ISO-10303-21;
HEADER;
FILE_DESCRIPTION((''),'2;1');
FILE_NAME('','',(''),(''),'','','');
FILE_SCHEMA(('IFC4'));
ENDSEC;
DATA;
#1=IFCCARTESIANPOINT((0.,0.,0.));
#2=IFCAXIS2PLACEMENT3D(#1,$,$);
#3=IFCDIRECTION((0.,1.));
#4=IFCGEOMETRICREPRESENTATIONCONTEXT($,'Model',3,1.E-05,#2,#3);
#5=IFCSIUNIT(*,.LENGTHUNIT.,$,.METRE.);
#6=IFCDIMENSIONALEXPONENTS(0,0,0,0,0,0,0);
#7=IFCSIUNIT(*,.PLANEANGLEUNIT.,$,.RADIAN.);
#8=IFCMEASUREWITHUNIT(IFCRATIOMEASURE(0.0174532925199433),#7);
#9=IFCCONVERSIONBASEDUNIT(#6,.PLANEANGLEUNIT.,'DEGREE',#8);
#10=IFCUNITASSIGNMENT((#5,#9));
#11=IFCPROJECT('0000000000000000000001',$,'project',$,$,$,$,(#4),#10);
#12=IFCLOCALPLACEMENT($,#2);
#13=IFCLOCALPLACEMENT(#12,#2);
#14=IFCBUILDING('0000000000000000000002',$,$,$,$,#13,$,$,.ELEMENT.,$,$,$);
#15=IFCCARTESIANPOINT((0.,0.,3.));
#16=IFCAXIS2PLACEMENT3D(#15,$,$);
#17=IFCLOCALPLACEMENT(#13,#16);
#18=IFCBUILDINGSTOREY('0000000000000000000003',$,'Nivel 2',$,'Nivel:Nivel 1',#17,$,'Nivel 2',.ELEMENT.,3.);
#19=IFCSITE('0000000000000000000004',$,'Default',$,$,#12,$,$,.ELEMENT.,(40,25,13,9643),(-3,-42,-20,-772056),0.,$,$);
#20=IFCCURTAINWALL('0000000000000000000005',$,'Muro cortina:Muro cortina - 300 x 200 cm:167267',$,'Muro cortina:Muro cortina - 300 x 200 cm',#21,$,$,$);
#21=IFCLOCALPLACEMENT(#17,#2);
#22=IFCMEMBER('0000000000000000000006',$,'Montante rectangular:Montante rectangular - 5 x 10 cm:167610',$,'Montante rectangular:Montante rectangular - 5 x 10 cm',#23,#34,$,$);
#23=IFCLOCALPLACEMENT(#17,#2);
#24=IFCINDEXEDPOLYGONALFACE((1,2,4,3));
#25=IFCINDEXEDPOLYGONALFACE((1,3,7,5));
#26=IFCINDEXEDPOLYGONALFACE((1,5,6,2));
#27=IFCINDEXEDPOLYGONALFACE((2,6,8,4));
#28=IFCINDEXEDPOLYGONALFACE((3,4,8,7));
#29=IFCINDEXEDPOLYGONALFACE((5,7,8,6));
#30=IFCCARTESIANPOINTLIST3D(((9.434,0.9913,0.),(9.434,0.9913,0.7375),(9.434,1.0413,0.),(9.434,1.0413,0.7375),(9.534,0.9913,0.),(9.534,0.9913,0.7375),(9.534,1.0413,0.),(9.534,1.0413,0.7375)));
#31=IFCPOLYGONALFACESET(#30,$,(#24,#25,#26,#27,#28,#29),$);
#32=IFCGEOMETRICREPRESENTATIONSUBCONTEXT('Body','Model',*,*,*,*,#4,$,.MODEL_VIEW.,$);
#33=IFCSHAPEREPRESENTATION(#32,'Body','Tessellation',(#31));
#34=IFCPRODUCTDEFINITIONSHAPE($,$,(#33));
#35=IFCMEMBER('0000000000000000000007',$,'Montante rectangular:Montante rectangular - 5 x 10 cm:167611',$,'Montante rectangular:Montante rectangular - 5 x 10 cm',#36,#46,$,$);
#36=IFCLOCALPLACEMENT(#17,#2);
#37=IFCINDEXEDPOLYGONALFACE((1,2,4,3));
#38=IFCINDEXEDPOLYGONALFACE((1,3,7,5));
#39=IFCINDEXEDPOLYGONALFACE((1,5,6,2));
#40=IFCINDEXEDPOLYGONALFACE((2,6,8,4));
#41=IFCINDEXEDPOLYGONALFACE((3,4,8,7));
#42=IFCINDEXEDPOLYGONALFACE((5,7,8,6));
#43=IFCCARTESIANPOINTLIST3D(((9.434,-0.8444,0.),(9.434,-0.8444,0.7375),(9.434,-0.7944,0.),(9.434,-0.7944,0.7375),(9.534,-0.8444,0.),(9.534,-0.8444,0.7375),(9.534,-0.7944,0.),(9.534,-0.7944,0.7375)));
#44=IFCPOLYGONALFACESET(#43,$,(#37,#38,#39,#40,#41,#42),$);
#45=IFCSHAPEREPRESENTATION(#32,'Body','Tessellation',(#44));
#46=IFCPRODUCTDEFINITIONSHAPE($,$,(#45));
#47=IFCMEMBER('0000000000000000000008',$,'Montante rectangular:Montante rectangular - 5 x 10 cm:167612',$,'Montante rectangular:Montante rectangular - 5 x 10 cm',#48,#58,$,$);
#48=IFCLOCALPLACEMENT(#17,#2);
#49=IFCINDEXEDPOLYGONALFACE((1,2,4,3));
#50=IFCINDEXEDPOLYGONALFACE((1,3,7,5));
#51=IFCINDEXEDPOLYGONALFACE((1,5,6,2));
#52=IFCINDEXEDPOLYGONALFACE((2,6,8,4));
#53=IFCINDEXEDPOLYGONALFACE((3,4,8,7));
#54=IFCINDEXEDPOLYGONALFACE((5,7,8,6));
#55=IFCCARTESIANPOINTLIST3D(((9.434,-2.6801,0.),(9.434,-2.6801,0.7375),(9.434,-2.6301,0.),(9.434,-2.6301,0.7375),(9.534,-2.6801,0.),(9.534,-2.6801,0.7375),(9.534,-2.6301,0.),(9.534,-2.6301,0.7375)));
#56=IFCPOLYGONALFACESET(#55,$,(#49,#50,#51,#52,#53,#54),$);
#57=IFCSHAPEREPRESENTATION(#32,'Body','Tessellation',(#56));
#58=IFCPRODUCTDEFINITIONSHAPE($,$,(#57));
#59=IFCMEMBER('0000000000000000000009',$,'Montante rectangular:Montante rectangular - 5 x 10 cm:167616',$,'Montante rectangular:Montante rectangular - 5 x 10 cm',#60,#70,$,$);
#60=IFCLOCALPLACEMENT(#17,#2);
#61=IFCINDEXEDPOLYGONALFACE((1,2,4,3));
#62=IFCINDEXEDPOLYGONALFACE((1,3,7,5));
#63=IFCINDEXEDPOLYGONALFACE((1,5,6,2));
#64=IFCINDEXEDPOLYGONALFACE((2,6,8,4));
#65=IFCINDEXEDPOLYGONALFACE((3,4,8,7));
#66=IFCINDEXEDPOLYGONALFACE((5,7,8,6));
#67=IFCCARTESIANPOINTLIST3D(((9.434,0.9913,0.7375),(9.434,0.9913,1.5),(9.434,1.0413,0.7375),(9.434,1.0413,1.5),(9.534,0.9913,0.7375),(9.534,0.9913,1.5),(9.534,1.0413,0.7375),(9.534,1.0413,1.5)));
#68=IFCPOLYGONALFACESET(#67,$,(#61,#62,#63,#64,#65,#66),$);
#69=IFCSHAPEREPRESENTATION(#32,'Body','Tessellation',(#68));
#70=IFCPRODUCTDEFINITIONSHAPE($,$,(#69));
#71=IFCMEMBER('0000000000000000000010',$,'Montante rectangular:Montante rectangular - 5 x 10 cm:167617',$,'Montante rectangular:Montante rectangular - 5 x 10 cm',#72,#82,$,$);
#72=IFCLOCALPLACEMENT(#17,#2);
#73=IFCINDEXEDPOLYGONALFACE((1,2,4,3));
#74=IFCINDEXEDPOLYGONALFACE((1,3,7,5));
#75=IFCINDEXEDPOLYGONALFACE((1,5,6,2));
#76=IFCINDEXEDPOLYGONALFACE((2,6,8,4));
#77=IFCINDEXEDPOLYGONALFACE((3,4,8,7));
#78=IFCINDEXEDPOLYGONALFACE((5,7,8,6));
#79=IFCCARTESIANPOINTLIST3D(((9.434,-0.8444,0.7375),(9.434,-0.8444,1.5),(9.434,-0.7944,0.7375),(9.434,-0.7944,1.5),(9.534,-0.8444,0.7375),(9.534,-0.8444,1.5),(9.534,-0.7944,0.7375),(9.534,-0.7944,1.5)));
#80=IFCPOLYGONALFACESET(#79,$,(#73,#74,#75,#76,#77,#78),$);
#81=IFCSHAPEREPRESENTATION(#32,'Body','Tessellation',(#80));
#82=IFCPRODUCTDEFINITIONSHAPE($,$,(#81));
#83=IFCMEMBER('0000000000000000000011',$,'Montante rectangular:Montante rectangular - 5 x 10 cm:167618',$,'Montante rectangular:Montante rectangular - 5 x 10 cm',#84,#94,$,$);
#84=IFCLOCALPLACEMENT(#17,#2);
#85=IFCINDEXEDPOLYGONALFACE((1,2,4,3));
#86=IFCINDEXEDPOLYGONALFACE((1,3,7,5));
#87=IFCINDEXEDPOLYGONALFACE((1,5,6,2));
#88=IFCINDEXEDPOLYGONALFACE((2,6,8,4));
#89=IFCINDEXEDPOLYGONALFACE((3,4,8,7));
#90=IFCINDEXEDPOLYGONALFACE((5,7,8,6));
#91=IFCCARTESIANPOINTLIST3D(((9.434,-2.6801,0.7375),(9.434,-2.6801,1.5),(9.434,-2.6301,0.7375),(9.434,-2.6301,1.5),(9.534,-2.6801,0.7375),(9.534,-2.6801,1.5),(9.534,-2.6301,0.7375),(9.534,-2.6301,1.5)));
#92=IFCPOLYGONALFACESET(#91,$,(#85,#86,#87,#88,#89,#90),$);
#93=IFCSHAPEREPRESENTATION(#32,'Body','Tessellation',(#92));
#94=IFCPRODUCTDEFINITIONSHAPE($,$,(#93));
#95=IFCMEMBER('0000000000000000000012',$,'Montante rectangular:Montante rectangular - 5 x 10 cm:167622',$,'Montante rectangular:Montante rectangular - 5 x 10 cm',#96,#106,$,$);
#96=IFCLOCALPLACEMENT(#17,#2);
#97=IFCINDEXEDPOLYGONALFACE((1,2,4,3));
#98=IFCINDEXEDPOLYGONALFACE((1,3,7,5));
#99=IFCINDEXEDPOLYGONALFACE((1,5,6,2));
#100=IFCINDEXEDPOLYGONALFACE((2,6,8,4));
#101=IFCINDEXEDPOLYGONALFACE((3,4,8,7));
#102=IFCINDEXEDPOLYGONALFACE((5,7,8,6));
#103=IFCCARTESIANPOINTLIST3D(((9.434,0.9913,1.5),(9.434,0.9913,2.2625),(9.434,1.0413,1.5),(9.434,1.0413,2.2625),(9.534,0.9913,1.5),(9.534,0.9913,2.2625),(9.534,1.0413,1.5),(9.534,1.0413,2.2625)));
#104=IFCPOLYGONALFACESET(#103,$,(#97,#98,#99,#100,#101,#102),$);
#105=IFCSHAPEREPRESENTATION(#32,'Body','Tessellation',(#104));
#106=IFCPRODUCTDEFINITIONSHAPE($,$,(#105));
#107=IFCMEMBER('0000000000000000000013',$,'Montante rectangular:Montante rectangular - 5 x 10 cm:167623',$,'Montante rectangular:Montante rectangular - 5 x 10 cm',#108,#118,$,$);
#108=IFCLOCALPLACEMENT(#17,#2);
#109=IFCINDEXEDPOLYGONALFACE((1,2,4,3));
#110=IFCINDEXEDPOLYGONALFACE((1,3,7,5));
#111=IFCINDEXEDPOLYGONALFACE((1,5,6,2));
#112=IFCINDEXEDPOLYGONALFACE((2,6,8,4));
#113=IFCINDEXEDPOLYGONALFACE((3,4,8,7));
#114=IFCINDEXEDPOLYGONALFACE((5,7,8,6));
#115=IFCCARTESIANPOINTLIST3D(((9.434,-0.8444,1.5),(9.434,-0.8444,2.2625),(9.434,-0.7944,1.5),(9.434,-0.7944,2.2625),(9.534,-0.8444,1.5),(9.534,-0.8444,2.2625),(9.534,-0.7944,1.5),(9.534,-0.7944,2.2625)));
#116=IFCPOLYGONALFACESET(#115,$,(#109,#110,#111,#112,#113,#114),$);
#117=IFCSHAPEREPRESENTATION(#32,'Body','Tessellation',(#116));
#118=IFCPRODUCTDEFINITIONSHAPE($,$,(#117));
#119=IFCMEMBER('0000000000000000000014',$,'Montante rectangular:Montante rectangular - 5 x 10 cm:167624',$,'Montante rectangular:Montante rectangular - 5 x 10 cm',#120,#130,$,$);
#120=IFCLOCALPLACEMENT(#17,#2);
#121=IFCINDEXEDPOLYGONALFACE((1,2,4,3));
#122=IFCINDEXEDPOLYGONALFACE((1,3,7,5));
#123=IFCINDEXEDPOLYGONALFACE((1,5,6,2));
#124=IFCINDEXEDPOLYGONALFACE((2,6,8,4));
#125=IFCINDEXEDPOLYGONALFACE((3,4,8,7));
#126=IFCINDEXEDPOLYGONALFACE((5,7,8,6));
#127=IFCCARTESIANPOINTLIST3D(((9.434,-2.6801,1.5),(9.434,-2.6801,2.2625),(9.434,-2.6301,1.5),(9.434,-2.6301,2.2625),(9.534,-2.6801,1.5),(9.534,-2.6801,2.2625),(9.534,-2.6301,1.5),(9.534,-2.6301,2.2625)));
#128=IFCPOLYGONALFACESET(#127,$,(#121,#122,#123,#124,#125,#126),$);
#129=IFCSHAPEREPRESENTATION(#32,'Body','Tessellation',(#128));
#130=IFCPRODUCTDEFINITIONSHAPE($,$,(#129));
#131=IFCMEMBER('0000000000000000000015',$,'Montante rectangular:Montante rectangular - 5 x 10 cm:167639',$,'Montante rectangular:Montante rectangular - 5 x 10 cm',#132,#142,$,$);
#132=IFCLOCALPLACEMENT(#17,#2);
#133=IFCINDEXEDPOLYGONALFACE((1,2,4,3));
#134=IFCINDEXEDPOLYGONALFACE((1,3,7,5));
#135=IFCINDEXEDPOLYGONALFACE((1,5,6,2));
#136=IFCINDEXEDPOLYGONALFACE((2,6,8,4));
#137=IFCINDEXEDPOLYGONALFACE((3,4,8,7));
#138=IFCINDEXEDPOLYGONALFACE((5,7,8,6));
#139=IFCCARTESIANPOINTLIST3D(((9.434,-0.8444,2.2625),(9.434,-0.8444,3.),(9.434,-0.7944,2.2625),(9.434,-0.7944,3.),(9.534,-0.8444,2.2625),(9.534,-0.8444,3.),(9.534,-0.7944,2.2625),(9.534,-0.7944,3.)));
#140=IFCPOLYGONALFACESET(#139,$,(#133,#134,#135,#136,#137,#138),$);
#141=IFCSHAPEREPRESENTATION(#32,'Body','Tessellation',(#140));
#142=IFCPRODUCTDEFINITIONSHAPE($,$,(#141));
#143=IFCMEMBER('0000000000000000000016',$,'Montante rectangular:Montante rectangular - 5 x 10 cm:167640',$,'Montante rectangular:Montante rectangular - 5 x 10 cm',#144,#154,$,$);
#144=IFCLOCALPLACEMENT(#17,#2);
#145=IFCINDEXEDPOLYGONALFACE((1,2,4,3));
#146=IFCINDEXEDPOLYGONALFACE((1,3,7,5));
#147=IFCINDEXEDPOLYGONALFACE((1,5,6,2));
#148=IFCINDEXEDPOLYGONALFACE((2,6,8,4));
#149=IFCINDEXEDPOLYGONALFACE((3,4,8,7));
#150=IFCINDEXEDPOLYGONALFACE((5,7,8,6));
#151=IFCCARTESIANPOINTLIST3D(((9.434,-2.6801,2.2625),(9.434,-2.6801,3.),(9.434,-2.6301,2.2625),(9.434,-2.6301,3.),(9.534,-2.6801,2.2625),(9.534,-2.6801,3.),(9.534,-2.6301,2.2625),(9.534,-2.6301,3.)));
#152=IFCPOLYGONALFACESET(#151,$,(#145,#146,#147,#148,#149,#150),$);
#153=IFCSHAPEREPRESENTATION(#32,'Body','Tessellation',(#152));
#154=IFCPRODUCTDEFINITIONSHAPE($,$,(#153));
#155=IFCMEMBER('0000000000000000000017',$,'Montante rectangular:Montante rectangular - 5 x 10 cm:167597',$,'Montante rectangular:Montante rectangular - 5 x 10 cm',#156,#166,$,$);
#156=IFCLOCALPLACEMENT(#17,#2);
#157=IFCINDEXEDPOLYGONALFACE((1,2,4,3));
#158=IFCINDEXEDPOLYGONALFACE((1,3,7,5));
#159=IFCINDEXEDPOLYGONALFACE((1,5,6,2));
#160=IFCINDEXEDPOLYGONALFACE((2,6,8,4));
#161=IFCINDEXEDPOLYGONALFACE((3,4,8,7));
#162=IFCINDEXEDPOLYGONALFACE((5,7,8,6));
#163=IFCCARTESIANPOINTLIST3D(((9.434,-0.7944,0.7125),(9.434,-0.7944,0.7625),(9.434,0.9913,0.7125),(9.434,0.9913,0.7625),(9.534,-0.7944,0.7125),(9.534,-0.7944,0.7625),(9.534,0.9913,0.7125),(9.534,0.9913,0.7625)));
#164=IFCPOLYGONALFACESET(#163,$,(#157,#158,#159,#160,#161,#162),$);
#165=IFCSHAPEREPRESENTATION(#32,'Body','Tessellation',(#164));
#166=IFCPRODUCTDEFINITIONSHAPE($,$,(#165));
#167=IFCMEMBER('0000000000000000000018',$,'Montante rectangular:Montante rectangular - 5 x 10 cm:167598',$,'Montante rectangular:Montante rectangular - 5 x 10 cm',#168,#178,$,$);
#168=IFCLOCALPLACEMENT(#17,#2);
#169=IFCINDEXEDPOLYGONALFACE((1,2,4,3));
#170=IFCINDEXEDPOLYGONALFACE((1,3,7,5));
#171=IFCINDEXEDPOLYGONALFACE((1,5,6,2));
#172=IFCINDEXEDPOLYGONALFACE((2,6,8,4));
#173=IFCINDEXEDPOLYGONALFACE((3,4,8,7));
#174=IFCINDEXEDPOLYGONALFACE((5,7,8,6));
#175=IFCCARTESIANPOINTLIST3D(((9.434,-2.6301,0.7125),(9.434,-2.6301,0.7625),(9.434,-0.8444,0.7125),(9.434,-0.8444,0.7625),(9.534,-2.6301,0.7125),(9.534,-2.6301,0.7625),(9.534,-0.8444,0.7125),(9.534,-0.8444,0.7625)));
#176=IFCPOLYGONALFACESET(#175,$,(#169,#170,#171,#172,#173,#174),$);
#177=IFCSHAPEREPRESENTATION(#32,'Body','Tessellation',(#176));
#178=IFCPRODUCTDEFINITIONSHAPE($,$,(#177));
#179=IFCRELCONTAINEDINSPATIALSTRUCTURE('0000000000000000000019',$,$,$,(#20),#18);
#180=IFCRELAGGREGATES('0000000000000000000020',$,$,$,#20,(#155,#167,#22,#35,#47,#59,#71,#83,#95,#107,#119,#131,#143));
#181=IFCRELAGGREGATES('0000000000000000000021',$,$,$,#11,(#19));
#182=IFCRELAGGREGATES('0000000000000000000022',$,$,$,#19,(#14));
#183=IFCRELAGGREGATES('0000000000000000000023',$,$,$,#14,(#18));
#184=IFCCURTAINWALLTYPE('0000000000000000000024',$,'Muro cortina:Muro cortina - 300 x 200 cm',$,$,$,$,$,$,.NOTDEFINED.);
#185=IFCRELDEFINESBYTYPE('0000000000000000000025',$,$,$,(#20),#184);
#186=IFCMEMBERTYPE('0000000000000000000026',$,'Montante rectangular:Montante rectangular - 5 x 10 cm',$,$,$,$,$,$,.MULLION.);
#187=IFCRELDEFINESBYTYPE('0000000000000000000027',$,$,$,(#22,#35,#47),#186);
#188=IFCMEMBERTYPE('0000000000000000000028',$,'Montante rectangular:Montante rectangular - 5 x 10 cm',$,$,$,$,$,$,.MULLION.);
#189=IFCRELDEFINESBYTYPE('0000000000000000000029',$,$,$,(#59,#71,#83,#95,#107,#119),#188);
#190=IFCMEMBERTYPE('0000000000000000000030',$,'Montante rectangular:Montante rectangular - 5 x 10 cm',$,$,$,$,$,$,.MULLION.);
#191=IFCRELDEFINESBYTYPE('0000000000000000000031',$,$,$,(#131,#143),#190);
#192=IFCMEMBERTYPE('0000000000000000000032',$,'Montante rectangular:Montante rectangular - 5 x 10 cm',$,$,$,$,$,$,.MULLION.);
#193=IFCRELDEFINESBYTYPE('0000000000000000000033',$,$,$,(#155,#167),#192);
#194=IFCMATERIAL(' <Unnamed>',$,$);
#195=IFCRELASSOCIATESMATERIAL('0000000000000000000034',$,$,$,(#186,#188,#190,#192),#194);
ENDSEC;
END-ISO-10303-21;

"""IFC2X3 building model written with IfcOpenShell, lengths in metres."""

from ifc_helpers import new_model, entity, si_unit, converted_unit, direction, frame, origin, origin_2d_with_axis, place, context, subcontext, project, spatial, rectangle, extrude, source, transform, mapped, material, type_object, type_shapes, element, aggregate, save


model = new_model("IFC2X3")

# Units and contexts
model_context = context("Model", 3, precision=1e-05, world=origin(), true_north=direction((0.0, 1.0)))
body_context = subcontext(model_context, "Body", "Model", "MODEL_VIEW")
ifc_project = project(units=[si_unit("LENGTHUNIT", "METRE"), converted_unit("PLANEANGLEUNIT", "DEGREE", entity("IfcRatioMeasure", 0.0174532925199433), si_unit("PLANEANGLEUNIT", "RADIAN"), dimensions=[0, 0, 0, 0, 0, 0, 0])], contexts=[model_context])

# Site, building, storey
site_placement = place(None, origin())
site = spatial("IfcSite", under=ifc_project, at=site_placement, Name="Default", CompositionType="ELEMENT", RefLatitude=(40, 25, 13, 9643), RefLongitude=(-3, -42, -20, -772056), RefElevation=0.0)
building_placement = place(site_placement, origin())
building = spatial("IfcBuilding", under=site, at=building_placement, CompositionType="ELEMENT")
storey_placement = place(building_placement, frame((0.0, 0.0, 3.0)))
storey = spatial("IfcBuildingStorey", under=building, at=storey_placement, Name="Nivel 2", ObjectType="Nivel:Nivel 1", LongName="Nivel 2", CompositionType="ELEMENT", Elevation=3.0)

# Curtain wall, members
curtain_wall_type = type_object("IfcCurtainWallType", Name="Muro cortina:Muro cortina - 300 x 200 cm", PredefinedType="NOTDEFINED")
curtain_wall_placement = place(storey_placement, frame((0.0, 0.0, -3.0)))
curtain_wall = element("IfcCurtainWall", 1, at=curtain_wall_placement, inside=storey, type_object=curtain_wall_type, Name="Muro cortina:Muro cortina - 300 x 200 cm:167267", ObjectType="Muro cortina:Muro cortina - 300 x 200 cm")
ifc_material_1 = material(Name=" <Unnamed>")
member_type_1 = type_object("IfcMemberType", Name="Montante rectangular:Montante rectangular - 5 x 10 cm", PredefinedType="MULLION", material=ifc_material_1)
shared_shape_1 = source(origin(), body_context, "Body", "SweptSolid", [
    extrude(rectangle(XDim=0.1, YDim=0.05, at=origin_2d_with_axis()), frame((0.0, 0.0, -0.7375), z_axis=(0.0, 0.0, 1.0), x_axis=(0.0, -1.0, 0.0)), (0.0, 0.0, 1.0), 0.7375),
])
type_shapes(member_type_1, [shared_shape_1])
member_1_placement = place(storey_placement, frame((9.484, 1.0163, 0.0), z_axis=(0.0, 0.0, -1.0), x_axis=(0.0, -1.0, 0.0)))
member_1 = element("IfcMember", 2, at=member_1_placement, type_object=member_type_1, Name="Montante rectangular:Montante rectangular - 5 x 10 cm:167610", ObjectType="Montante rectangular:Montante rectangular - 5 x 10 cm", context=body_context, shape_type="MappedRepresentation", body=[
    mapped(shared_shape_1, transform((0.0, 0.0, 0.0), scale=1.0)),
])
member_2_placement = place(storey_placement, frame((9.484, -0.8194, 0.0), z_axis=(0.0, 0.0, -1.0), x_axis=(0.0, -1.0, 0.0)))
member_2 = element("IfcMember", 3, at=member_2_placement, type_object=member_type_1, Name="Montante rectangular:Montante rectangular - 5 x 10 cm:167611", ObjectType="Montante rectangular:Montante rectangular - 5 x 10 cm", context=body_context, shape_type="MappedRepresentation", body=[
    mapped(shared_shape_1, transform((0.0, 0.0, 0.0), scale=1.0)),
])
member_3_placement = place(storey_placement, frame((9.484, -2.6551, 0.0), z_axis=(0.0, 0.0, -1.0), x_axis=(0.0, -1.0, 0.0)))
member_3 = element("IfcMember", 4, at=member_3_placement, type_object=member_type_1, Name="Montante rectangular:Montante rectangular - 5 x 10 cm:167612", ObjectType="Montante rectangular:Montante rectangular - 5 x 10 cm", context=body_context, shape_type="MappedRepresentation", body=[
    mapped(shared_shape_1, transform((0.0, 0.0, 0.0), scale=1.0)),
])
member_type_2 = type_object("IfcMemberType", Name="Montante rectangular:Montante rectangular - 5 x 10 cm", PredefinedType="MULLION", material=ifc_material_1)
shared_shape_2 = source(origin(), body_context, "Body", "SweptSolid", [
    extrude(rectangle(XDim=0.1, YDim=0.05, at=origin_2d_with_axis()), frame((0.0, 0.0, -0.7625), z_axis=(0.0, 0.0, 1.0), x_axis=(0.0, -1.0, 0.0)), (0.0, 0.0, 1.0), 0.7625),
])
type_shapes(member_type_2, [shared_shape_2])
member_4_placement = place(storey_placement, frame((9.484, 1.0163, 0.7375), z_axis=(0.0, 0.0, -1.0), x_axis=(0.0, -1.0, 0.0)))
member_4 = element("IfcMember", 5, at=member_4_placement, type_object=member_type_2, Name="Montante rectangular:Montante rectangular - 5 x 10 cm:167616", ObjectType="Montante rectangular:Montante rectangular - 5 x 10 cm", context=body_context, shape_type="MappedRepresentation", body=[
    mapped(shared_shape_2, transform((0.0, 0.0, 0.0), scale=1.0)),
])
member_5_placement = place(storey_placement, frame((9.484, -0.8194, 0.7375), z_axis=(0.0, 0.0, -1.0), x_axis=(0.0, -1.0, 0.0)))
member_5 = element("IfcMember", 6, at=member_5_placement, type_object=member_type_2, Name="Montante rectangular:Montante rectangular - 5 x 10 cm:167617", ObjectType="Montante rectangular:Montante rectangular - 5 x 10 cm", context=body_context, shape_type="MappedRepresentation", body=[
    mapped(shared_shape_2, transform((0.0, 0.0, 0.0), scale=1.0)),
])
member_6_placement = place(storey_placement, frame((9.484, -2.6551, 0.7375), z_axis=(0.0, 0.0, -1.0), x_axis=(0.0, -1.0, 0.0)))
member_6 = element("IfcMember", 7, at=member_6_placement, type_object=member_type_2, Name="Montante rectangular:Montante rectangular - 5 x 10 cm:167618", ObjectType="Montante rectangular:Montante rectangular - 5 x 10 cm", context=body_context, shape_type="MappedRepresentation", body=[
    mapped(shared_shape_2, transform((0.0, 0.0, 0.0), scale=1.0)),
])
member_7_placement = place(storey_placement, frame((9.484, 1.0163, 1.5), z_axis=(0.0, 0.0, -1.0), x_axis=(0.0, -1.0, 0.0)))
member_7 = element("IfcMember", 8, at=member_7_placement, type_object=member_type_2, Name="Montante rectangular:Montante rectangular - 5 x 10 cm:167622", ObjectType="Montante rectangular:Montante rectangular - 5 x 10 cm", context=body_context, shape_type="MappedRepresentation", body=[
    mapped(shared_shape_2, transform((0.0, 0.0, 0.0), scale=1.0)),
])
member_8_placement = place(storey_placement, frame((9.484, -0.8194, 1.5), z_axis=(0.0, 0.0, -1.0), x_axis=(0.0, -1.0, 0.0)))
member_8 = element("IfcMember", 9, at=member_8_placement, type_object=member_type_2, Name="Montante rectangular:Montante rectangular - 5 x 10 cm:167623", ObjectType="Montante rectangular:Montante rectangular - 5 x 10 cm", context=body_context, shape_type="MappedRepresentation", body=[
    mapped(shared_shape_2, transform((0.0, 0.0, 0.0), scale=1.0)),
])
member_9_placement = place(storey_placement, frame((9.484, -2.6551, 1.5), z_axis=(0.0, 0.0, -1.0), x_axis=(0.0, -1.0, 0.0)))
member_9 = element("IfcMember", 10, at=member_9_placement, type_object=member_type_2, Name="Montante rectangular:Montante rectangular - 5 x 10 cm:167624", ObjectType="Montante rectangular:Montante rectangular - 5 x 10 cm", context=body_context, shape_type="MappedRepresentation", body=[
    mapped(shared_shape_2, transform((0.0, 0.0, 0.0), scale=1.0)),
])
member_type_3 = type_object("IfcMemberType", Name="Montante rectangular:Montante rectangular - 5 x 10 cm", PredefinedType="MULLION", material=ifc_material_1)
shared_shape_3 = source(origin(), body_context, "Body", "SweptSolid", [
    extrude(rectangle(XDim=0.1, YDim=0.05, at=origin_2d_with_axis()), frame((0.0, 0.0, -0.7375), z_axis=(0.0, 0.0, 1.0), x_axis=(0.0, -1.0, 0.0)), (0.0, 0.0, 1.0), 0.7375),
])
type_shapes(member_type_3, [shared_shape_3])
member_10_placement = place(storey_placement, frame((9.484, -0.8194, 2.2625), z_axis=(0.0, 0.0, -1.0), x_axis=(0.0, -1.0, 0.0)))
member_10 = element("IfcMember", 11, at=member_10_placement, type_object=member_type_3, Name="Montante rectangular:Montante rectangular - 5 x 10 cm:167639", ObjectType="Montante rectangular:Montante rectangular - 5 x 10 cm", context=body_context, shape_type="MappedRepresentation", body=[
    mapped(shared_shape_3, transform((0.0, 0.0, 0.0), scale=1.0)),
])
member_11_placement = place(storey_placement, frame((9.484, -2.6551, 2.2625), z_axis=(0.0, 0.0, -1.0), x_axis=(0.0, -1.0, 0.0)))
member_11 = element("IfcMember", 12, at=member_11_placement, type_object=member_type_3, Name="Montante rectangular:Montante rectangular - 5 x 10 cm:167640", ObjectType="Montante rectangular:Montante rectangular - 5 x 10 cm", context=body_context, shape_type="MappedRepresentation", body=[
    mapped(shared_shape_3, transform((0.0, 0.0, 0.0), scale=1.0)),
])
member_type_4 = type_object("IfcMemberType", Name="Montante rectangular:Montante rectangular - 5 x 10 cm", PredefinedType="MULLION", material=ifc_material_1)
shared_shape_4 = source(origin(), body_context, "Body", "SweptSolid", [
    extrude(rectangle(XDim=0.1, YDim=0.05, at=origin_2d_with_axis()), frame((0.0, 0.0, -1.7857), z_axis=(0.0, 0.0, 1.0), x_axis=(0.0, -1.0, 0.0)), (0.0, 0.0, 1.0), 1.7857),
])
type_shapes(member_type_4, [shared_shape_4])
member_12_placement = place(storey_placement, frame((9.484, -0.7944, 0.7375), z_axis=(0.0, -1.0, 0.0), x_axis=(0.0, 0.0, 1.0)))
member_12 = element("IfcMember", 13, at=member_12_placement, type_object=member_type_4, Name="Montante rectangular:Montante rectangular - 5 x 10 cm:167597", ObjectType="Montante rectangular:Montante rectangular - 5 x 10 cm", context=body_context, shape_type="MappedRepresentation", body=[
    mapped(shared_shape_4, transform((0.0, 0.0, 0.0), scale=1.0)),
])
member_13_placement = place(storey_placement, frame((9.484, -2.6301, 0.7375), z_axis=(0.0, -1.0, 0.0), x_axis=(0.0, 0.0, 1.0)))
member_13 = element("IfcMember", 14, at=member_13_placement, type_object=member_type_4, Name="Montante rectangular:Montante rectangular - 5 x 10 cm:167598", ObjectType="Montante rectangular:Montante rectangular - 5 x 10 cm", context=body_context, shape_type="MappedRepresentation", body=[
    mapped(shared_shape_4, transform((0.0, 0.0, 0.0), scale=1.0)),
])
aggregate(curtain_wall, [member_12, member_13, member_1, member_2, member_3, member_4, member_5, member_6, member_7, member_8, member_9, member_10, member_11])

save(model, "model.ifc")
